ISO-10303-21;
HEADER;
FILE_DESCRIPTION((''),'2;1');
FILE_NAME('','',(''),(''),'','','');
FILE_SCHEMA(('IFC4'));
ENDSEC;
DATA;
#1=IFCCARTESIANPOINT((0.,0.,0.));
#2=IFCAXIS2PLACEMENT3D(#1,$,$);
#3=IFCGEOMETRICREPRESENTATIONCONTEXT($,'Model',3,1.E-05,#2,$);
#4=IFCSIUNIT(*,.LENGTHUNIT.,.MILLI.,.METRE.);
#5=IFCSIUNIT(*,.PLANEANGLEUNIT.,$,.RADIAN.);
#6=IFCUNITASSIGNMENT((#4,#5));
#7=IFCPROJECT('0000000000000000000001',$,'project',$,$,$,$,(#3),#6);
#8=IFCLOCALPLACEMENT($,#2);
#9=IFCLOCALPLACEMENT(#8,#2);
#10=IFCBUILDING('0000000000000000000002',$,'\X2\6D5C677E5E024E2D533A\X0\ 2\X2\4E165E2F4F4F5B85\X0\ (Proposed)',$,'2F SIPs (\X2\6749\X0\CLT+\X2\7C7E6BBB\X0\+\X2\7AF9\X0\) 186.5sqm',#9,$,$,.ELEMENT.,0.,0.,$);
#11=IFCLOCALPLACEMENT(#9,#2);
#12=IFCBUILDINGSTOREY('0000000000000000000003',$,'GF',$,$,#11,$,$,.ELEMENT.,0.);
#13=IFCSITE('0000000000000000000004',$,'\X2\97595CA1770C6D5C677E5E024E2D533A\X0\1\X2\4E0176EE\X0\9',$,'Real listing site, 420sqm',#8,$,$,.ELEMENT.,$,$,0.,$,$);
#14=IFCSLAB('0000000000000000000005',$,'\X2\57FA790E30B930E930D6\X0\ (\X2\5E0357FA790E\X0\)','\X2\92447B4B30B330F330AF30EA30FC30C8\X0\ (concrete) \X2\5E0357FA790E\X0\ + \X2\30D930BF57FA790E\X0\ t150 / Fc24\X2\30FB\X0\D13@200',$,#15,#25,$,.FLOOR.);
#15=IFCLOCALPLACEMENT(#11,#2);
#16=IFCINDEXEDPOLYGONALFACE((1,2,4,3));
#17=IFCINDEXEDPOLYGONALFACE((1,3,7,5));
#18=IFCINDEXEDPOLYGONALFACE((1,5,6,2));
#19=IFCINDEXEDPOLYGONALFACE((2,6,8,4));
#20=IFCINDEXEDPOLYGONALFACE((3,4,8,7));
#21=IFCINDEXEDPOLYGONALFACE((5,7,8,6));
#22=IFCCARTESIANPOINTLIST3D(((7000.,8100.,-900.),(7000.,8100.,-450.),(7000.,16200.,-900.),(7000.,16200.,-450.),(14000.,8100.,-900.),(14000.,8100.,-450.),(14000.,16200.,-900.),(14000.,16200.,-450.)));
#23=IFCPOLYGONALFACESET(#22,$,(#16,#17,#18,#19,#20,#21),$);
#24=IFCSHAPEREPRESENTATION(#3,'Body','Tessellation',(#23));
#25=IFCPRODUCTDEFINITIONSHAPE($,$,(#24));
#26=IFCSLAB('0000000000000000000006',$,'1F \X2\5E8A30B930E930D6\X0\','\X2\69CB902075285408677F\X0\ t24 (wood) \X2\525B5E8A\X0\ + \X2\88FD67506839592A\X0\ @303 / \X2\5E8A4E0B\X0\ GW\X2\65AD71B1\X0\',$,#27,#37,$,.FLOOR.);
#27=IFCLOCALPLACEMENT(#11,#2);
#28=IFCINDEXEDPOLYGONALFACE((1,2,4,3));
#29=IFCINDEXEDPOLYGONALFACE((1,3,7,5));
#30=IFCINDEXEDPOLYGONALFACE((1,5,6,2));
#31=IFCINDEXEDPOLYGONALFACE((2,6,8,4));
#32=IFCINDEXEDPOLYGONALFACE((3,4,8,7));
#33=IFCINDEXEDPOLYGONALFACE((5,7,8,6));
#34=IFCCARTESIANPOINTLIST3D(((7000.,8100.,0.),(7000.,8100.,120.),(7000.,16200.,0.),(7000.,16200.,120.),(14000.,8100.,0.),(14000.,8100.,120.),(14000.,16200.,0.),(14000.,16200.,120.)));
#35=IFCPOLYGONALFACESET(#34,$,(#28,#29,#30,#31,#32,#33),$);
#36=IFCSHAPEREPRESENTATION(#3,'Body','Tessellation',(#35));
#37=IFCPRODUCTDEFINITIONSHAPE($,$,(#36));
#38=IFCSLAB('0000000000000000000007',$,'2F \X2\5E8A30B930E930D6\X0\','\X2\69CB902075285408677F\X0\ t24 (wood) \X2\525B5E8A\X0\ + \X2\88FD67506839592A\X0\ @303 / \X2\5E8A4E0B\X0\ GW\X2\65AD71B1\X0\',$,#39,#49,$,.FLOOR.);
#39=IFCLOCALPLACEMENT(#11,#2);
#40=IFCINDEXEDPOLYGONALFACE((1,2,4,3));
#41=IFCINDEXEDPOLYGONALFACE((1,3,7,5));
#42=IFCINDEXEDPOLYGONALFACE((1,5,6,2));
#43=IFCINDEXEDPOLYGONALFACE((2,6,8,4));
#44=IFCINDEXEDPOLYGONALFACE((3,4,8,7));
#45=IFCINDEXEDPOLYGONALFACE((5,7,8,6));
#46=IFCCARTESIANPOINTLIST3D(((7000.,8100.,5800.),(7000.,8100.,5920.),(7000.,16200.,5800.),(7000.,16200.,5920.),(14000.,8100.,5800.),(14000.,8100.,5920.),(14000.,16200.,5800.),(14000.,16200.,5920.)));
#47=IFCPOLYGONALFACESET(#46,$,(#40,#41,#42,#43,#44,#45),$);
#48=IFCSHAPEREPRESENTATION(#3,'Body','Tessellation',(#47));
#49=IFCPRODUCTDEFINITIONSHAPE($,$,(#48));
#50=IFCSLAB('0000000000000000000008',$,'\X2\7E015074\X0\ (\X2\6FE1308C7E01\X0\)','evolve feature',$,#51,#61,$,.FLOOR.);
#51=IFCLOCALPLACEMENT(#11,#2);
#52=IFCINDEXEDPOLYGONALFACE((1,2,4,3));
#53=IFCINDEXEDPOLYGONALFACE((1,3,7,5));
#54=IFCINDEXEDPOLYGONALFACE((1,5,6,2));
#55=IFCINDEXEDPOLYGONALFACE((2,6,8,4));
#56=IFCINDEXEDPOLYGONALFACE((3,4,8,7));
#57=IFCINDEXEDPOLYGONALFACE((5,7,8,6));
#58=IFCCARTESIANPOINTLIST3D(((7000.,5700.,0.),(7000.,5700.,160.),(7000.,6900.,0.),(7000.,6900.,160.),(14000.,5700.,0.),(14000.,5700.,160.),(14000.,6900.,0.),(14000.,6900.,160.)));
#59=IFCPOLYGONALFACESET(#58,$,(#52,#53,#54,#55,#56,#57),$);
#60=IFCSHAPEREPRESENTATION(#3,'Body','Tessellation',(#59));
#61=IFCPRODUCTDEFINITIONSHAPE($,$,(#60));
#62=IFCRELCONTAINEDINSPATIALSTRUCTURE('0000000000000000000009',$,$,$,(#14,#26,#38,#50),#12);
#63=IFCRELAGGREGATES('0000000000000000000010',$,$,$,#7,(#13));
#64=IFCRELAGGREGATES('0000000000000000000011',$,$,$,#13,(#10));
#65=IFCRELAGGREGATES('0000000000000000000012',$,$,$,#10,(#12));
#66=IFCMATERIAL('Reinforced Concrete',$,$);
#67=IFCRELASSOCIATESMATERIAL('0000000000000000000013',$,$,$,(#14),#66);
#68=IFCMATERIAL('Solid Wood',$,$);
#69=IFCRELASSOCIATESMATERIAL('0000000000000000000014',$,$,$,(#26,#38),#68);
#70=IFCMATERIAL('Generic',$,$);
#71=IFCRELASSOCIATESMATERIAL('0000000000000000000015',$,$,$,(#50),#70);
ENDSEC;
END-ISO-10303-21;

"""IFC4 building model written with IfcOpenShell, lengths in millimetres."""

from ifc_helpers import new_model, si_unit, frame, frame_2d, origin, place, context, project, spatial, rectangle, extrude, material, element, save


model = new_model("IFC4")

# Units and contexts
model_context = context("Model", 3, precision=1e-05, world=origin())
ifc_project = project(units=[si_unit("LENGTHUNIT", "METRE", prefix="MILLI"), si_unit("PLANEANGLEUNIT", "RADIAN")], contexts=[model_context])

# Site, building, storey
site_placement = place(None, origin())
site = spatial("IfcSite", under=ifc_project, at=site_placement, Name="静岡県浜松市中区1丁目9", ObjectType="Real listing site, 420sqm", CompositionType="ELEMENT", RefElevation=0.0)
building_placement = place(site_placement, origin())
building = spatial("IfcBuilding", under=site, at=building_placement, Name="浜松市中区 2世帯住宅 (Proposed)", ObjectType="2F SIPs (杉CLT+籾殻+竹) 186.5sqm", CompositionType="ELEMENT", ElevationOfRefHeight=0.0, ElevationOfTerrain=0.0)
storey_placement = place(building_placement, origin())
storey = spatial("IfcBuildingStorey", under=building, at=storey_placement, Name="GF", CompositionType="ELEMENT", Elevation=0.0)

# Slabs
ifc_material_1 = material(Name="Reinforced Concrete")
slab_1_placement = place(storey_placement, frame((3500.0, 4050.0, -450.0)))
element("IfcSlab", 1, at=slab_1_placement, inside=storey, material=ifc_material_1, Name="基礎スラブ (布基礎)", Description="鉄筋コンクリート (concrete) 布基礎 + ベタ基礎 t150 / Fc24・D13@200", PredefinedType="FLOOR", context=model_context, shape_type="SweptSolid", body=[
    extrude(rectangle(XDim=7000.0, YDim=8100.0, at=frame_2d((3500.0, 4050.0))), frame((3500.0, 4050.0, -450.0)), (0.0, 0.0, 1.0), 450.0),
])
ifc_material_2 = material(Name="Solid Wood")
slab_2_placement = place(storey_placement, frame((3500.0, 4050.0, 0.0)))
element("IfcSlab", 2, at=slab_2_placement, inside=storey, material=ifc_material_2, Name="1F 床スラブ", Description="構造用合板 t24 (wood) 剛床 + 製材根太 @303 / 床下 GW断熱", PredefinedType="FLOOR", context=model_context, shape_type="SweptSolid", body=[
    extrude(rectangle(XDim=7000.0, YDim=8100.0, at=frame_2d((3500.0, 4050.0))), frame((3500.0, 4050.0, 0.0)), (0.0, 0.0, 1.0), 120.0),
])
slab_3_placement = place(storey_placement, frame((3500.0, 4050.0, 2900.0)))
element("IfcSlab", 3, at=slab_3_placement, inside=storey, material=ifc_material_2, Name="2F 床スラブ", Description="構造用合板 t24 (wood) 剛床 + 製材根太 @303 / 床下 GW断熱", PredefinedType="FLOOR", context=model_context, shape_type="SweptSolid", body=[
    extrude(rectangle(XDim=7000.0, YDim=8100.0, at=frame_2d((3500.0, 4050.0))), frame((3500.0, 4050.0, 2900.0)), (0.0, 0.0, 1.0), 120.0),
])
ifc_material_3 = material(Name="Generic")
slab_4_placement = place(storey_placement, frame((3500.0, 2850.0, 0.0)))
element("IfcSlab", 4, at=slab_4_placement, inside=storey, material=ifc_material_3, Name="縁側 (濡れ縁)", Description="evolve feature", PredefinedType="FLOOR", context=model_context, shape_type="SweptSolid", body=[
    extrude(rectangle(XDim=7000.0, YDim=1200.0, at=frame_2d((3500.0, 600.0))), frame((3500.0, 2850.0, 0.0)), (0.0, 0.0, 1.0), 160.0),
])

save(model, "model.ifc")
